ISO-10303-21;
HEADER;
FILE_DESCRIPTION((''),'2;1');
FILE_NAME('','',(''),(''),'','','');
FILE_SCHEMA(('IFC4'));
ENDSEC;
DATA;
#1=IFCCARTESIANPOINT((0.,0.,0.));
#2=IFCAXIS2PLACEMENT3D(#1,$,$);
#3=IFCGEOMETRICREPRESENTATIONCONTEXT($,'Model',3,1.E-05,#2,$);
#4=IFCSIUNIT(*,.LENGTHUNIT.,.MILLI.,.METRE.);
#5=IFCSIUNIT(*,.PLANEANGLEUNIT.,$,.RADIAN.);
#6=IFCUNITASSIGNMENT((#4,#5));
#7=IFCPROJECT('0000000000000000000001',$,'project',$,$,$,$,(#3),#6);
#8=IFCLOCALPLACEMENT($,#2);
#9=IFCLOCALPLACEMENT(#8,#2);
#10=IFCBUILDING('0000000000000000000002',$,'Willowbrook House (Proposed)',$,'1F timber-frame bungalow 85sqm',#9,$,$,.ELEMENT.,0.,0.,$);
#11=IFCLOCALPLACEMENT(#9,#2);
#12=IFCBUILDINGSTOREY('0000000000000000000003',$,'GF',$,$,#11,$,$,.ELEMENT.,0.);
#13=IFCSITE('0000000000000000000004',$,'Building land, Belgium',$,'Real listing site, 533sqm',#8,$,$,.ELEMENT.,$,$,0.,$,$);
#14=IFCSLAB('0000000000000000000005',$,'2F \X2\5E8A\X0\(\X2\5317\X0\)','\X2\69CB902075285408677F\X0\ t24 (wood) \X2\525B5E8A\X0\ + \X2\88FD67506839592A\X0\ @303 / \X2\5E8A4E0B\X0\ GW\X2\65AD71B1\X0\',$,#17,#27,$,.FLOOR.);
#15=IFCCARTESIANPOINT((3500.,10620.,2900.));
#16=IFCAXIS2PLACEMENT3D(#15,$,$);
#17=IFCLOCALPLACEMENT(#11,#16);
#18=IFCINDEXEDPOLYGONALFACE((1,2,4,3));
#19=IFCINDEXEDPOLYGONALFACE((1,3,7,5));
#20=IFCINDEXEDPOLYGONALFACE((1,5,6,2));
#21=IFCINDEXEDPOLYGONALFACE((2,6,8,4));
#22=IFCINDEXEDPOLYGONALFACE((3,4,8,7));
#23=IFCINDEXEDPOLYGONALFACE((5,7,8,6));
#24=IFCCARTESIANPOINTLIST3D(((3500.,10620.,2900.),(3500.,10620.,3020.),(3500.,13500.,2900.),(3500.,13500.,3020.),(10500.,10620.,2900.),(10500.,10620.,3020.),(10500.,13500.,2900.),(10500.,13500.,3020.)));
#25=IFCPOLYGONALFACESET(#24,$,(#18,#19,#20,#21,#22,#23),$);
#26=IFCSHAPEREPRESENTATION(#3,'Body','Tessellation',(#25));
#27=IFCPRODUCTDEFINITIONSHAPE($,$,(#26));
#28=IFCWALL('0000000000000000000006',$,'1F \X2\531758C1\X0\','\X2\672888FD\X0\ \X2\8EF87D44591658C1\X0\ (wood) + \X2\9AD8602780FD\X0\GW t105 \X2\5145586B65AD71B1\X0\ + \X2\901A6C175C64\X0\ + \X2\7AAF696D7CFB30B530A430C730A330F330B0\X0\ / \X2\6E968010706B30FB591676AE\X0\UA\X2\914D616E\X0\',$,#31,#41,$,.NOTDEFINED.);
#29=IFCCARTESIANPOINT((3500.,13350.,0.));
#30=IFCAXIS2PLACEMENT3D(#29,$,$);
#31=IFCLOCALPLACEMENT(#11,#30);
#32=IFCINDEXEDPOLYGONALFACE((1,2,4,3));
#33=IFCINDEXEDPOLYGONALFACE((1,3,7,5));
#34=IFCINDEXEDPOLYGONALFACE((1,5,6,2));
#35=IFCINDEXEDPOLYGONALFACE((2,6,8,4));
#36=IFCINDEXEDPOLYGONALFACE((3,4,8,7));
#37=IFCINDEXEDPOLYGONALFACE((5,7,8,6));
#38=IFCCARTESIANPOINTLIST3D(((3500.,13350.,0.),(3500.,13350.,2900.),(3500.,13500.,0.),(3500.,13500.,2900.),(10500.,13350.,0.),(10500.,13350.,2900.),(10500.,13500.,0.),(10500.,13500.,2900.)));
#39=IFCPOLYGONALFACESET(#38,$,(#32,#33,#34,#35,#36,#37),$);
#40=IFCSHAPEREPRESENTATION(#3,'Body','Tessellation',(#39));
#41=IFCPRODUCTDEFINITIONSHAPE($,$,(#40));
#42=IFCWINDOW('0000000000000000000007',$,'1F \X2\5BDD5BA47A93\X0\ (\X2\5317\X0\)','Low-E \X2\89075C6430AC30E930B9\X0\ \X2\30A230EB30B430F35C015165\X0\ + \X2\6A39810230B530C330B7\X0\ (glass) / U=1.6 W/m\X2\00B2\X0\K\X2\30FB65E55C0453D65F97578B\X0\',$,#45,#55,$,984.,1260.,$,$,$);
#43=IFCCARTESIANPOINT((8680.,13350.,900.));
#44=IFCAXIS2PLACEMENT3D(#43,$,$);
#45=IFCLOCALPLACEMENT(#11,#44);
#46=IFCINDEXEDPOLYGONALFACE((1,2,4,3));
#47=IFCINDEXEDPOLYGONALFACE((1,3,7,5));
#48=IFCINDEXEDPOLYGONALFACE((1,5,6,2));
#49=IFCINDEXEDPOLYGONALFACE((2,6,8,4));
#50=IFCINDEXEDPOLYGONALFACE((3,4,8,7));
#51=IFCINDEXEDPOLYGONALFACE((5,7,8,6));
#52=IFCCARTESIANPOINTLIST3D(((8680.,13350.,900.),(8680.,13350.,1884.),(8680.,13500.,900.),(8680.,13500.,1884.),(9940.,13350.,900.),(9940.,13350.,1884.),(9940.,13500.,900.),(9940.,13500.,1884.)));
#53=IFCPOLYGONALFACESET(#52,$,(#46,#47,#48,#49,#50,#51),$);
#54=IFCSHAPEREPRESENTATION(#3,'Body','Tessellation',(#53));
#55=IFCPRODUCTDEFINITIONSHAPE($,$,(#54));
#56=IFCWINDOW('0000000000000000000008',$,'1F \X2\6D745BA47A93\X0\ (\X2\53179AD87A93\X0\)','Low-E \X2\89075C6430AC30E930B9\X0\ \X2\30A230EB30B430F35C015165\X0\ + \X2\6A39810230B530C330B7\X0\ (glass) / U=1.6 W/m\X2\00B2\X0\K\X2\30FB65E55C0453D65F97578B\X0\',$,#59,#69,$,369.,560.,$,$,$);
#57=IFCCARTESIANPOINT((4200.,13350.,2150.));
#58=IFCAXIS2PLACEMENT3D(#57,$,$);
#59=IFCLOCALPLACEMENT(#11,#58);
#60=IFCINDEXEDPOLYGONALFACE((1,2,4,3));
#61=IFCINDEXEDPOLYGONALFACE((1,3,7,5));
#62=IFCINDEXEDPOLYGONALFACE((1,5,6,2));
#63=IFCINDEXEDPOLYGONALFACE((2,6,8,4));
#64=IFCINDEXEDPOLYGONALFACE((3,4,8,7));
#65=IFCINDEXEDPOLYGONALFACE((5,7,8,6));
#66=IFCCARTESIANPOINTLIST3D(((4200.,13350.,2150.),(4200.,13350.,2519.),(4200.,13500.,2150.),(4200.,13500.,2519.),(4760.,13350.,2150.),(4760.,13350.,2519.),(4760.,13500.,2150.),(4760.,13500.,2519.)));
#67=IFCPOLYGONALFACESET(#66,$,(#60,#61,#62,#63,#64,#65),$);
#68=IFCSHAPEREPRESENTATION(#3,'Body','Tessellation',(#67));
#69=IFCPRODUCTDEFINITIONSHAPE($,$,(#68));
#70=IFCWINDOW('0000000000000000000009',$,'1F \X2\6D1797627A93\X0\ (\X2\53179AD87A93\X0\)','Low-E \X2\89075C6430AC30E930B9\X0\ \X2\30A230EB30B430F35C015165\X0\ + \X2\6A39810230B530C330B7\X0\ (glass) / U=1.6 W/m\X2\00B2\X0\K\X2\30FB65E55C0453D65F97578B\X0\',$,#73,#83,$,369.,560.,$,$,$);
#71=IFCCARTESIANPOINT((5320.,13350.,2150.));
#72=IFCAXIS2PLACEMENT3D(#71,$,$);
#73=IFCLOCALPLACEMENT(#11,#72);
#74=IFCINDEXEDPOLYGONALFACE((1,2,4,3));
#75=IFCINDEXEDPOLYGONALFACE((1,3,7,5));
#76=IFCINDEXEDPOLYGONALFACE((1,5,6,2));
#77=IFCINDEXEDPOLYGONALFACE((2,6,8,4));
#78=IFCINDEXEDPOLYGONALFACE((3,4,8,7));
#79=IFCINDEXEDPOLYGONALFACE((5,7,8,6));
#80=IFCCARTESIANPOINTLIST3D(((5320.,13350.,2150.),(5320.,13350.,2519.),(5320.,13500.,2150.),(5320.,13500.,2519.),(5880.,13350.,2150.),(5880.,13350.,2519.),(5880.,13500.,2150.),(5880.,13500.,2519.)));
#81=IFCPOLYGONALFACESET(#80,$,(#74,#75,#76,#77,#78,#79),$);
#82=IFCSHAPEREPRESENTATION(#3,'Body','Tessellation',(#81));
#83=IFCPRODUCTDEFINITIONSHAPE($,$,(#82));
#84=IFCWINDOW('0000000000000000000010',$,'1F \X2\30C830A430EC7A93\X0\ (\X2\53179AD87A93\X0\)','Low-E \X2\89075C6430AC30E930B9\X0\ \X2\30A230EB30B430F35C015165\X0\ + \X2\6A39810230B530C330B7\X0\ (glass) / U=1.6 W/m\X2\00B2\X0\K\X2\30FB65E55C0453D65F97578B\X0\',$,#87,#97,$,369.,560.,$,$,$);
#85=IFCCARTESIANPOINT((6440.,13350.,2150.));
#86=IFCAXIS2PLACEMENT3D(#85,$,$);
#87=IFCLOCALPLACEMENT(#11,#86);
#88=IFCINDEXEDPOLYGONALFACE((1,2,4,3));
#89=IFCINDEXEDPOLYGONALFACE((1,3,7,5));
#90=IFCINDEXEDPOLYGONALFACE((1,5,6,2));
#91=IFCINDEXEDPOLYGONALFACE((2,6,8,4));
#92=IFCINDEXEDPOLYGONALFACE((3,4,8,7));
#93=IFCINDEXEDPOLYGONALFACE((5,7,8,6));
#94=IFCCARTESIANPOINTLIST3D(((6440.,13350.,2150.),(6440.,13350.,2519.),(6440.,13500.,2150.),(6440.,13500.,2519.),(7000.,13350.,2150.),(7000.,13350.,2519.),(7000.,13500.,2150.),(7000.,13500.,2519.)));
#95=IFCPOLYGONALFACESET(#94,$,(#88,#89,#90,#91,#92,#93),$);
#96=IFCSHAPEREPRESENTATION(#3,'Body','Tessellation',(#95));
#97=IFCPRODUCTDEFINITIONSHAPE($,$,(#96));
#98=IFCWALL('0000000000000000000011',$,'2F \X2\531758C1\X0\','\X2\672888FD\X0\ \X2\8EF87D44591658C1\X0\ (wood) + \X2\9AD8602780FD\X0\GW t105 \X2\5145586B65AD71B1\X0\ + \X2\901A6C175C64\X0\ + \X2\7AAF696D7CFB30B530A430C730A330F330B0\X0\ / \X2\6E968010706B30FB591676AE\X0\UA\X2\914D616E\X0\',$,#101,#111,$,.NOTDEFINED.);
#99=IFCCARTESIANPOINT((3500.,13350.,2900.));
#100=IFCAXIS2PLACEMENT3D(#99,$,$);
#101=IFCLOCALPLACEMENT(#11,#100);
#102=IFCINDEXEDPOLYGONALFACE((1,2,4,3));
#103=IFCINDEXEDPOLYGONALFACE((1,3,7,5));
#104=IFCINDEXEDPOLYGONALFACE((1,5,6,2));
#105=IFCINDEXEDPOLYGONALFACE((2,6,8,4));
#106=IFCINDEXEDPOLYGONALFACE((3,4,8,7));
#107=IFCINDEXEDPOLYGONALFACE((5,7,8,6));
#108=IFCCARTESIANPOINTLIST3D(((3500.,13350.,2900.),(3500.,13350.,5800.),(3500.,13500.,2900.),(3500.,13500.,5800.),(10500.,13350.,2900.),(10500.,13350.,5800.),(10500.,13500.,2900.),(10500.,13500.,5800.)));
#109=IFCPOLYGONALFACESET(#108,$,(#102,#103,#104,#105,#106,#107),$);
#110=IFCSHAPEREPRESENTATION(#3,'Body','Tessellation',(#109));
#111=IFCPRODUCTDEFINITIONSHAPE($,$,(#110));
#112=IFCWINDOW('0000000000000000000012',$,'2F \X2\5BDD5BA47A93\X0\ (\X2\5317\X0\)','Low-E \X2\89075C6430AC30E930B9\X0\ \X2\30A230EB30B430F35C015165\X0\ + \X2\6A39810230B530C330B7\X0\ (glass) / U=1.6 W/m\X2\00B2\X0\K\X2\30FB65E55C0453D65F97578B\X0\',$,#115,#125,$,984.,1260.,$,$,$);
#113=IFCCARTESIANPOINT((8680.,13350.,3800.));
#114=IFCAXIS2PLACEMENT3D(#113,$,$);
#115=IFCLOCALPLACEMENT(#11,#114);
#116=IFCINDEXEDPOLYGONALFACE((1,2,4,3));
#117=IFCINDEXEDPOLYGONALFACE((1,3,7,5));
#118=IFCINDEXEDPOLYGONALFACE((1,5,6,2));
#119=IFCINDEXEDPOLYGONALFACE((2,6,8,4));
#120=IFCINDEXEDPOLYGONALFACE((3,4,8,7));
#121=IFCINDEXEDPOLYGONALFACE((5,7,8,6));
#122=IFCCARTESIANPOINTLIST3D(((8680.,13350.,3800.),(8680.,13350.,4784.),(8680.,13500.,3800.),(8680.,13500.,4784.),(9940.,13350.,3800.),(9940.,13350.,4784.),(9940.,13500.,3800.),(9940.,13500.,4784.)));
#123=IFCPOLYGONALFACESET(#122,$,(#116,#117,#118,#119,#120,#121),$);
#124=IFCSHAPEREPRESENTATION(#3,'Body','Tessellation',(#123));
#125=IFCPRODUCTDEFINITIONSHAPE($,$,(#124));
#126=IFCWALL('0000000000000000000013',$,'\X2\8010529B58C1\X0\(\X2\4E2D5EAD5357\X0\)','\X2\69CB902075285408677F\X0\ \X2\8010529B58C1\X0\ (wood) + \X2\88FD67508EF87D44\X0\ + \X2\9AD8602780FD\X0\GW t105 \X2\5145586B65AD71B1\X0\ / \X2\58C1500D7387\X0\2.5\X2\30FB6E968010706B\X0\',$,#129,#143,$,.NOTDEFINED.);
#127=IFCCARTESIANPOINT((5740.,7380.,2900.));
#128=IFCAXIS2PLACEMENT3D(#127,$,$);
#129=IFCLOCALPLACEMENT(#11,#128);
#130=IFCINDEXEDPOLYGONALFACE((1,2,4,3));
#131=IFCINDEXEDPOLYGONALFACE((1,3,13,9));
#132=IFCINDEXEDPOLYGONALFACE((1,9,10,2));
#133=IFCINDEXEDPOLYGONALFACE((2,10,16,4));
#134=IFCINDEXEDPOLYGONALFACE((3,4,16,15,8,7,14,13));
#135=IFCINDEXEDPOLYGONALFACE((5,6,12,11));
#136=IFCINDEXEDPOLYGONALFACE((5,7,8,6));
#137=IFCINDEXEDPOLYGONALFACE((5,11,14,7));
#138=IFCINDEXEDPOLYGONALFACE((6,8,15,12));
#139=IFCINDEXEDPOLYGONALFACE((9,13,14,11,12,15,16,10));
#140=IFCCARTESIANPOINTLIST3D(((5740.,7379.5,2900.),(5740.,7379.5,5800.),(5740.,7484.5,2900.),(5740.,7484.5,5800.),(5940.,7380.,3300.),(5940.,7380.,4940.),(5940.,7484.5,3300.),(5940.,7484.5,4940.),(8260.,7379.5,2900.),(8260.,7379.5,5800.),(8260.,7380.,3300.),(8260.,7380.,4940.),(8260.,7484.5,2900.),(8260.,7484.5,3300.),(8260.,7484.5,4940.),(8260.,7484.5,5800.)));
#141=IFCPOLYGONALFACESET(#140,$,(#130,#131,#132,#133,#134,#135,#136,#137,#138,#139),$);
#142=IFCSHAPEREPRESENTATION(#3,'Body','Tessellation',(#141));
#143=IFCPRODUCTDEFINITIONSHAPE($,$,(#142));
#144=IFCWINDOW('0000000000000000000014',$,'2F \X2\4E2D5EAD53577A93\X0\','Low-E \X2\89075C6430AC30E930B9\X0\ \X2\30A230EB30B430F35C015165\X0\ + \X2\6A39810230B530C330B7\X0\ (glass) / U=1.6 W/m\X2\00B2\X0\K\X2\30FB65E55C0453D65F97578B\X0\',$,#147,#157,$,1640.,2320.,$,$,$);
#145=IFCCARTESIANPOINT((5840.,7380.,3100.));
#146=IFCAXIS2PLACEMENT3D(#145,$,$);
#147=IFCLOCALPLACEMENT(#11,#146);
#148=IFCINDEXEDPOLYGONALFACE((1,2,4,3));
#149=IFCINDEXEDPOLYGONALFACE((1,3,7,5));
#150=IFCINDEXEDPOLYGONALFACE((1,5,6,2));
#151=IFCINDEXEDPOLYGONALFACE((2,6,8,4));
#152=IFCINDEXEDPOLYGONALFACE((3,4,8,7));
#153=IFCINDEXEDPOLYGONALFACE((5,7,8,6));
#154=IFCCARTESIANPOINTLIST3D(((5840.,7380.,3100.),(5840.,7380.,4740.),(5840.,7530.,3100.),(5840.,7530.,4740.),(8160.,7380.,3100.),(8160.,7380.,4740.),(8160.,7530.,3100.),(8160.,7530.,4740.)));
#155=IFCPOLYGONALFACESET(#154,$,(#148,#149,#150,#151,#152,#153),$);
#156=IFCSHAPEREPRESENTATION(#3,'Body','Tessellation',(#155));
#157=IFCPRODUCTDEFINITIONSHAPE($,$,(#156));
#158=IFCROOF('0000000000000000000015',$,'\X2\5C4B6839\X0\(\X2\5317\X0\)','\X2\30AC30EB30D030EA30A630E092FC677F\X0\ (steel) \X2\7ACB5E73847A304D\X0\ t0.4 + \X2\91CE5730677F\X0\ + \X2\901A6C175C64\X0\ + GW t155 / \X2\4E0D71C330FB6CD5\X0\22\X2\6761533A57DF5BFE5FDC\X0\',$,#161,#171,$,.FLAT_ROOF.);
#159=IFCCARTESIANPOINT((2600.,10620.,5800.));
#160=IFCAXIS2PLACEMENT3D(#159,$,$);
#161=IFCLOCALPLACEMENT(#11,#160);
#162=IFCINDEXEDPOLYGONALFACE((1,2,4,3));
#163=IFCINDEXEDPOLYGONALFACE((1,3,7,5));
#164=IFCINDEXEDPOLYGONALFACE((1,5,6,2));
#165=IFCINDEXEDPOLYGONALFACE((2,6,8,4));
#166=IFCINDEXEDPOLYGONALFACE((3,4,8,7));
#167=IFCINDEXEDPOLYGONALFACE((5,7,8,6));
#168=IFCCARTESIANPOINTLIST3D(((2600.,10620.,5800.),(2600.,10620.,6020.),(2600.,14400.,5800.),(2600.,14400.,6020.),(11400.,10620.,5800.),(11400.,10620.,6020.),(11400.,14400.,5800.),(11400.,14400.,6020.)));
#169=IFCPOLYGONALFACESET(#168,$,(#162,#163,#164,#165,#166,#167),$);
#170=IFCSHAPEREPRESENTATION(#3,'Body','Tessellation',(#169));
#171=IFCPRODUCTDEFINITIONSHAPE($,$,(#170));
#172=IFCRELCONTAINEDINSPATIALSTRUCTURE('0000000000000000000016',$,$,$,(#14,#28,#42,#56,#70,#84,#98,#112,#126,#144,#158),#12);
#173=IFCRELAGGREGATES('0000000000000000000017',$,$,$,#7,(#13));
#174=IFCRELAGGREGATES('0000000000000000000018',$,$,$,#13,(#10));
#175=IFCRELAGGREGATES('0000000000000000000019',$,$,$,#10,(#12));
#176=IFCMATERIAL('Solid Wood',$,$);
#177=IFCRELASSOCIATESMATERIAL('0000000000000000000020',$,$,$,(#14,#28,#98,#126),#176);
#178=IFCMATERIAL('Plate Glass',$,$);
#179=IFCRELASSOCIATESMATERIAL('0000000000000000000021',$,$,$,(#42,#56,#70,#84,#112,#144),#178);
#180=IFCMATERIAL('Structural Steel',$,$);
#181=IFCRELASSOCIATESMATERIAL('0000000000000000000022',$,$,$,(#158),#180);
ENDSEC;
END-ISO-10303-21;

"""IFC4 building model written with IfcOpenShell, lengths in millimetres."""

from ifc_helpers import new_model, si_unit, frame, frame_2d, origin, place, context, project, spatial, rectangle, extrude, material, element, fill, save


model = new_model("IFC4")

# Units and contexts
model_context = context("Model", 3, precision=1e-05, world=origin())
ifc_project = project(units=[si_unit("LENGTHUNIT", "METRE", prefix="MILLI"), si_unit("PLANEANGLEUNIT", "RADIAN")], contexts=[model_context])

# Site, building, storey
site_placement = place(None, origin())
site = spatial("IfcSite", under=ifc_project, at=site_placement, Name="Building land, Belgium", ObjectType="Real listing site, 533sqm", CompositionType="ELEMENT", RefElevation=0.0)
building_placement = place(site_placement, origin())
building = spatial("IfcBuilding", under=site, at=building_placement, Name="Willowbrook House (Proposed)", ObjectType="1F timber-frame bungalow 85sqm", CompositionType="ELEMENT", ElevationOfRefHeight=0.0, ElevationOfTerrain=0.0)
storey_placement = place(building_placement, origin())
storey = spatial("IfcBuildingStorey", under=building, at=storey_placement, Name="GF", CompositionType="ELEMENT", Elevation=0.0)

# Slab
ifc_material_1 = material(Name="Solid Wood")
slab_1_placement = place(storey_placement, frame((3500.0, 10620.0, 2900.0)))
element("IfcSlab", 1, at=slab_1_placement, inside=storey, material=ifc_material_1, Name="2F 床(北)", Description="構造用合板 t24 (wood) 剛床 + 製材根太 @303 / 床下 GW断熱", PredefinedType="FLOOR", context=model_context, shape_type="SweptSolid", body=[
    extrude(rectangle(XDim=7000.0, YDim=2880.0, at=frame_2d((3500.0, 1440.0))), frame((3500.0, 10620.0, 2900.0)), (0.0, 0.0, 1.0), 120.0),
])

# Wall, openings, windows
wall_1_placement = place(storey_placement, frame((3500.0, 13350.0, 0.0)))
wall_1 = element("IfcWall", 2, at=wall_1_placement, inside=storey, material=ifc_material_1, Name="1F 北壁", Description="木製 軸組外壁 (wood) + 高性能GW t105 充填断熱 + 通気層 + 窯業系サイディング / 準耐火・外皮UA配慮", PredefinedType="NOTDEFINED", context=model_context, shape_type="SweptSolid", body=[
    extrude(rectangle(XDim=7000.0, YDim=150.0, at=frame_2d((3500.0, 75.0))), frame((3500.0, 13350.0, 0.0)), (0.0, 0.0, 1.0), 2900.0),
])
opening_1_placement = place(storey_placement, frame((8680.0, 13350.0, 900.0)))
opening_1 = element("IfcOpeningElement", 3, at=opening_1_placement, cuts=wall_1, PredefinedType="NOTDEFINED", context=model_context, shape_type="SweptSolid", body=[
    extrude(rectangle(XDim=1260.0, YDim=150.0, at=frame_2d((630.0, 75.0))), frame((8680.0, 13350.0, 900.0)), (0.0, 0.0, 1.0), 984.0),
])
opening_2_placement = place(storey_placement, frame((4200.0, 13350.0, 2150.0)))
opening_2 = element("IfcOpeningElement", 4, at=opening_2_placement, cuts=wall_1, PredefinedType="NOTDEFINED", context=model_context, shape_type="SweptSolid", body=[
    extrude(rectangle(XDim=560.0, YDim=150.0, at=frame_2d((280.0, 75.0))), frame((4200.0, 13350.0, 2150.0)), (0.0, 0.0, 1.0), 369.0),
])
opening_3_placement = place(storey_placement, frame((5320.0, 13350.0, 2150.0)))
opening_3 = element("IfcOpeningElement", 5, at=opening_3_placement, cuts=wall_1, PredefinedType="NOTDEFINED", context=model_context, shape_type="SweptSolid", body=[
    extrude(rectangle(XDim=560.0, YDim=150.0, at=frame_2d((280.0, 75.0))), frame((5320.0, 13350.0, 2150.0)), (0.0, 0.0, 1.0), 369.0),
])
opening_4_placement = place(storey_placement, frame((6440.0, 13350.0, 2150.0)))
opening_4 = element("IfcOpeningElement", 6, at=opening_4_placement, cuts=wall_1, PredefinedType="NOTDEFINED", context=model_context, shape_type="SweptSolid", body=[
    extrude(rectangle(XDim=560.0, YDim=150.0, at=frame_2d((280.0, 75.0))), frame((6440.0, 13350.0, 2150.0)), (0.0, 0.0, 1.0), 369.0),
])
ifc_material_2 = material(Name="Plate Glass")
window_1_placement = place(storey_placement, frame((8680.0, 13350.0, 900.0)))
window_1 = element("IfcWindow", 7, at=window_1_placement, inside=storey, material=ifc_material_2, Name="1F 寝室窓 (北)", Description="Low-E 複層ガラス アルゴン封入 + 樹脂サッシ (glass) / U=1.6 W/m²K・日射取得型", OverallHeight=984.0, OverallWidth=1260.0, context=model_context, shape_type="SweptSolid", body=[
    extrude(rectangle(XDim=1260.0, YDim=150.0, at=frame_2d((630.0, 75.0))), frame((8680.0, 13350.0, 900.0)), (0.0, 0.0, 1.0), 984.0),
])
fill(opening_1, window_1)
window_2_placement = place(storey_placement, frame((4200.0, 13350.0, 2150.0)))
window_2 = element("IfcWindow", 8, at=window_2_placement, inside=storey, material=ifc_material_2, Name="1F 浴室窓 (北高窓)", Description="Low-E 複層ガラス アルゴン封入 + 樹脂サッシ (glass) / U=1.6 W/m²K・日射取得型", OverallHeight=369.0, OverallWidth=560.0, context=model_context, shape_type="SweptSolid", body=[
    extrude(rectangle(XDim=560.0, YDim=150.0, at=frame_2d((280.0, 75.0))), frame((4200.0, 13350.0, 2150.0)), (0.0, 0.0, 1.0), 369.0),
])
fill(opening_2, window_2)
window_3_placement = place(storey_placement, frame((5320.0, 13350.0, 2150.0)))
window_3 = element("IfcWindow", 9, at=window_3_placement, inside=storey, material=ifc_material_2, Name="1F 洗面窓 (北高窓)", Description="Low-E 複層ガラス アルゴン封入 + 樹脂サッシ (glass) / U=1.6 W/m²K・日射取得型", OverallHeight=369.0, OverallWidth=560.0, context=model_context, shape_type="SweptSolid", body=[
    extrude(rectangle(XDim=560.0, YDim=150.0, at=frame_2d((280.0, 75.0))), frame((5320.0, 13350.0, 2150.0)), (0.0, 0.0, 1.0), 369.0),
])
fill(opening_3, window_3)
window_4_placement = place(storey_placement, frame((6440.0, 13350.0, 2150.0)))
window_4 = element("IfcWindow", 10, at=window_4_placement, inside=storey, material=ifc_material_2, Name="1F トイレ窓 (北高窓)", Description="Low-E 複層ガラス アルゴン封入 + 樹脂サッシ (glass) / U=1.6 W/m²K・日射取得型", OverallHeight=369.0, OverallWidth=560.0, context=model_context, shape_type="SweptSolid", body=[
    extrude(rectangle(XDim=560.0, YDim=150.0, at=frame_2d((280.0, 75.0))), frame((6440.0, 13350.0, 2150.0)), (0.0, 0.0, 1.0), 369.0),
])
fill(opening_4, window_4)

# Walls, openings, windows
wall_2_placement = place(storey_placement, frame((3500.0, 13350.0, 2900.0)))
wall_2 = element("IfcWall", 11, at=wall_2_placement, inside=storey, material=ifc_material_1, Name="2F 北壁", Description="木製 軸組外壁 (wood) + 高性能GW t105 充填断熱 + 通気層 + 窯業系サイディング / 準耐火・外皮UA配慮", PredefinedType="NOTDEFINED", context=model_context, shape_type="SweptSolid", body=[
    extrude(rectangle(XDim=7000.0, YDim=150.0, at=frame_2d((3500.0, 75.0))), frame((3500.0, 13350.0, 2900.0)), (0.0, 0.0, 1.0), 2900.0),
])
opening_5_placement = place(storey_placement, frame((8680.0, 13350.0, 3800.0)))
opening_5 = element("IfcOpeningElement", 12, at=opening_5_placement, cuts=wall_2, PredefinedType="NOTDEFINED", context=model_context, shape_type="SweptSolid", body=[
    extrude(rectangle(XDim=1260.0, YDim=150.0, at=frame_2d((630.0, 75.0))), frame((8680.0, 13350.0, 3800.0)), (0.0, 0.0, 1.0), 984.0),
])
window_5_placement = place(storey_placement, frame((8680.0, 13350.0, 3800.0)))
window_5 = element("IfcWindow", 13, at=window_5_placement, inside=storey, material=ifc_material_2, Name="2F 寝室窓 (北)", Description="Low-E 複層ガラス アルゴン封入 + 樹脂サッシ (glass) / U=1.6 W/m²K・日射取得型", OverallHeight=984.0, OverallWidth=1260.0, context=model_context, shape_type="SweptSolid", body=[
    extrude(rectangle(XDim=1260.0, YDim=150.0, at=frame_2d((630.0, 75.0))), frame((8680.0, 13350.0, 3800.0)), (0.0, 0.0, 1.0), 984.0),
])
fill(opening_5, window_5)
wall_3_placement = place(storey_placement, frame((5740.0, 7380.0, 2900.0)))
wall_3 = element("IfcWall", 14, at=wall_3_placement, inside=storey, material=ifc_material_1, Name="耐力壁(中庭南)", Description="構造用合板 耐力壁 (wood) + 製材軸組 + 高性能GW t105 充填断熱 / 壁倍率2.5・準耐火", PredefinedType="NOTDEFINED", context=model_context, shape_type="SweptSolid", body=[
    extrude(rectangle(XDim=2520.0, YDim=105.0, at=frame_2d((1260.0, 52.0))), frame((5740.0, 7380.0, 2900.0)), (0.0, 0.0, 1.0), 2900.0),
])
opening_6_placement = place(storey_placement, frame((5840.0, 7380.0, 3100.0)))
opening_6 = element("IfcOpeningElement", 15, at=opening_6_placement, cuts=wall_3, PredefinedType="NOTDEFINED", context=model_context, shape_type="SweptSolid", body=[
    extrude(rectangle(XDim=2320.0, YDim=150.0, at=frame_2d((1160.0, 75.0))), frame((5840.0, 7380.0, 3100.0)), (0.0, 0.0, 1.0), 1640.0),
])
window_6_placement = place(storey_placement, frame((5840.0, 7380.0, 3100.0)))
window_6 = element("IfcWindow", 16, at=window_6_placement, inside=storey, material=ifc_material_2, Name="2F 中庭南窓", Description="Low-E 複層ガラス アルゴン封入 + 樹脂サッシ (glass) / U=1.6 W/m²K・日射取得型", OverallHeight=1640.0, OverallWidth=2320.0, context=model_context, shape_type="SweptSolid", body=[
    extrude(rectangle(XDim=2320.0, YDim=150.0, at=frame_2d((1160.0, 75.0))), frame((5840.0, 7380.0, 3100.0)), (0.0, 0.0, 1.0), 1640.0),
])
fill(opening_6, window_6)

# Roof
ifc_material_3 = material(Name="Structural Steel")
for number, where, name in (
    (17, (2600.0, 10620.0, 5800.0), "屋根(北)"),
):
    element("IfcRoof", number, at=place(storey_placement, frame(where)), inside=storey, material=ifc_material_3, Name=name, Description="ガルバリウム鋼板 (steel) 立平葺き t0.4 + 野地板 + 通気層 + GW t155 / 不燃・法22条区域対応", PredefinedType="FLAT_ROOF", context=model_context, shape_type="SweptSolid", body=[
        extrude(rectangle(XDim=8800.0, YDim=3780.0, at=frame_2d((4400.0, 1890.0))), frame((2600.0, 10620.0, 5800.0)), (0.0, 0.0, 1.0), 220.0),
    ])

save(model, "model.ifc")
